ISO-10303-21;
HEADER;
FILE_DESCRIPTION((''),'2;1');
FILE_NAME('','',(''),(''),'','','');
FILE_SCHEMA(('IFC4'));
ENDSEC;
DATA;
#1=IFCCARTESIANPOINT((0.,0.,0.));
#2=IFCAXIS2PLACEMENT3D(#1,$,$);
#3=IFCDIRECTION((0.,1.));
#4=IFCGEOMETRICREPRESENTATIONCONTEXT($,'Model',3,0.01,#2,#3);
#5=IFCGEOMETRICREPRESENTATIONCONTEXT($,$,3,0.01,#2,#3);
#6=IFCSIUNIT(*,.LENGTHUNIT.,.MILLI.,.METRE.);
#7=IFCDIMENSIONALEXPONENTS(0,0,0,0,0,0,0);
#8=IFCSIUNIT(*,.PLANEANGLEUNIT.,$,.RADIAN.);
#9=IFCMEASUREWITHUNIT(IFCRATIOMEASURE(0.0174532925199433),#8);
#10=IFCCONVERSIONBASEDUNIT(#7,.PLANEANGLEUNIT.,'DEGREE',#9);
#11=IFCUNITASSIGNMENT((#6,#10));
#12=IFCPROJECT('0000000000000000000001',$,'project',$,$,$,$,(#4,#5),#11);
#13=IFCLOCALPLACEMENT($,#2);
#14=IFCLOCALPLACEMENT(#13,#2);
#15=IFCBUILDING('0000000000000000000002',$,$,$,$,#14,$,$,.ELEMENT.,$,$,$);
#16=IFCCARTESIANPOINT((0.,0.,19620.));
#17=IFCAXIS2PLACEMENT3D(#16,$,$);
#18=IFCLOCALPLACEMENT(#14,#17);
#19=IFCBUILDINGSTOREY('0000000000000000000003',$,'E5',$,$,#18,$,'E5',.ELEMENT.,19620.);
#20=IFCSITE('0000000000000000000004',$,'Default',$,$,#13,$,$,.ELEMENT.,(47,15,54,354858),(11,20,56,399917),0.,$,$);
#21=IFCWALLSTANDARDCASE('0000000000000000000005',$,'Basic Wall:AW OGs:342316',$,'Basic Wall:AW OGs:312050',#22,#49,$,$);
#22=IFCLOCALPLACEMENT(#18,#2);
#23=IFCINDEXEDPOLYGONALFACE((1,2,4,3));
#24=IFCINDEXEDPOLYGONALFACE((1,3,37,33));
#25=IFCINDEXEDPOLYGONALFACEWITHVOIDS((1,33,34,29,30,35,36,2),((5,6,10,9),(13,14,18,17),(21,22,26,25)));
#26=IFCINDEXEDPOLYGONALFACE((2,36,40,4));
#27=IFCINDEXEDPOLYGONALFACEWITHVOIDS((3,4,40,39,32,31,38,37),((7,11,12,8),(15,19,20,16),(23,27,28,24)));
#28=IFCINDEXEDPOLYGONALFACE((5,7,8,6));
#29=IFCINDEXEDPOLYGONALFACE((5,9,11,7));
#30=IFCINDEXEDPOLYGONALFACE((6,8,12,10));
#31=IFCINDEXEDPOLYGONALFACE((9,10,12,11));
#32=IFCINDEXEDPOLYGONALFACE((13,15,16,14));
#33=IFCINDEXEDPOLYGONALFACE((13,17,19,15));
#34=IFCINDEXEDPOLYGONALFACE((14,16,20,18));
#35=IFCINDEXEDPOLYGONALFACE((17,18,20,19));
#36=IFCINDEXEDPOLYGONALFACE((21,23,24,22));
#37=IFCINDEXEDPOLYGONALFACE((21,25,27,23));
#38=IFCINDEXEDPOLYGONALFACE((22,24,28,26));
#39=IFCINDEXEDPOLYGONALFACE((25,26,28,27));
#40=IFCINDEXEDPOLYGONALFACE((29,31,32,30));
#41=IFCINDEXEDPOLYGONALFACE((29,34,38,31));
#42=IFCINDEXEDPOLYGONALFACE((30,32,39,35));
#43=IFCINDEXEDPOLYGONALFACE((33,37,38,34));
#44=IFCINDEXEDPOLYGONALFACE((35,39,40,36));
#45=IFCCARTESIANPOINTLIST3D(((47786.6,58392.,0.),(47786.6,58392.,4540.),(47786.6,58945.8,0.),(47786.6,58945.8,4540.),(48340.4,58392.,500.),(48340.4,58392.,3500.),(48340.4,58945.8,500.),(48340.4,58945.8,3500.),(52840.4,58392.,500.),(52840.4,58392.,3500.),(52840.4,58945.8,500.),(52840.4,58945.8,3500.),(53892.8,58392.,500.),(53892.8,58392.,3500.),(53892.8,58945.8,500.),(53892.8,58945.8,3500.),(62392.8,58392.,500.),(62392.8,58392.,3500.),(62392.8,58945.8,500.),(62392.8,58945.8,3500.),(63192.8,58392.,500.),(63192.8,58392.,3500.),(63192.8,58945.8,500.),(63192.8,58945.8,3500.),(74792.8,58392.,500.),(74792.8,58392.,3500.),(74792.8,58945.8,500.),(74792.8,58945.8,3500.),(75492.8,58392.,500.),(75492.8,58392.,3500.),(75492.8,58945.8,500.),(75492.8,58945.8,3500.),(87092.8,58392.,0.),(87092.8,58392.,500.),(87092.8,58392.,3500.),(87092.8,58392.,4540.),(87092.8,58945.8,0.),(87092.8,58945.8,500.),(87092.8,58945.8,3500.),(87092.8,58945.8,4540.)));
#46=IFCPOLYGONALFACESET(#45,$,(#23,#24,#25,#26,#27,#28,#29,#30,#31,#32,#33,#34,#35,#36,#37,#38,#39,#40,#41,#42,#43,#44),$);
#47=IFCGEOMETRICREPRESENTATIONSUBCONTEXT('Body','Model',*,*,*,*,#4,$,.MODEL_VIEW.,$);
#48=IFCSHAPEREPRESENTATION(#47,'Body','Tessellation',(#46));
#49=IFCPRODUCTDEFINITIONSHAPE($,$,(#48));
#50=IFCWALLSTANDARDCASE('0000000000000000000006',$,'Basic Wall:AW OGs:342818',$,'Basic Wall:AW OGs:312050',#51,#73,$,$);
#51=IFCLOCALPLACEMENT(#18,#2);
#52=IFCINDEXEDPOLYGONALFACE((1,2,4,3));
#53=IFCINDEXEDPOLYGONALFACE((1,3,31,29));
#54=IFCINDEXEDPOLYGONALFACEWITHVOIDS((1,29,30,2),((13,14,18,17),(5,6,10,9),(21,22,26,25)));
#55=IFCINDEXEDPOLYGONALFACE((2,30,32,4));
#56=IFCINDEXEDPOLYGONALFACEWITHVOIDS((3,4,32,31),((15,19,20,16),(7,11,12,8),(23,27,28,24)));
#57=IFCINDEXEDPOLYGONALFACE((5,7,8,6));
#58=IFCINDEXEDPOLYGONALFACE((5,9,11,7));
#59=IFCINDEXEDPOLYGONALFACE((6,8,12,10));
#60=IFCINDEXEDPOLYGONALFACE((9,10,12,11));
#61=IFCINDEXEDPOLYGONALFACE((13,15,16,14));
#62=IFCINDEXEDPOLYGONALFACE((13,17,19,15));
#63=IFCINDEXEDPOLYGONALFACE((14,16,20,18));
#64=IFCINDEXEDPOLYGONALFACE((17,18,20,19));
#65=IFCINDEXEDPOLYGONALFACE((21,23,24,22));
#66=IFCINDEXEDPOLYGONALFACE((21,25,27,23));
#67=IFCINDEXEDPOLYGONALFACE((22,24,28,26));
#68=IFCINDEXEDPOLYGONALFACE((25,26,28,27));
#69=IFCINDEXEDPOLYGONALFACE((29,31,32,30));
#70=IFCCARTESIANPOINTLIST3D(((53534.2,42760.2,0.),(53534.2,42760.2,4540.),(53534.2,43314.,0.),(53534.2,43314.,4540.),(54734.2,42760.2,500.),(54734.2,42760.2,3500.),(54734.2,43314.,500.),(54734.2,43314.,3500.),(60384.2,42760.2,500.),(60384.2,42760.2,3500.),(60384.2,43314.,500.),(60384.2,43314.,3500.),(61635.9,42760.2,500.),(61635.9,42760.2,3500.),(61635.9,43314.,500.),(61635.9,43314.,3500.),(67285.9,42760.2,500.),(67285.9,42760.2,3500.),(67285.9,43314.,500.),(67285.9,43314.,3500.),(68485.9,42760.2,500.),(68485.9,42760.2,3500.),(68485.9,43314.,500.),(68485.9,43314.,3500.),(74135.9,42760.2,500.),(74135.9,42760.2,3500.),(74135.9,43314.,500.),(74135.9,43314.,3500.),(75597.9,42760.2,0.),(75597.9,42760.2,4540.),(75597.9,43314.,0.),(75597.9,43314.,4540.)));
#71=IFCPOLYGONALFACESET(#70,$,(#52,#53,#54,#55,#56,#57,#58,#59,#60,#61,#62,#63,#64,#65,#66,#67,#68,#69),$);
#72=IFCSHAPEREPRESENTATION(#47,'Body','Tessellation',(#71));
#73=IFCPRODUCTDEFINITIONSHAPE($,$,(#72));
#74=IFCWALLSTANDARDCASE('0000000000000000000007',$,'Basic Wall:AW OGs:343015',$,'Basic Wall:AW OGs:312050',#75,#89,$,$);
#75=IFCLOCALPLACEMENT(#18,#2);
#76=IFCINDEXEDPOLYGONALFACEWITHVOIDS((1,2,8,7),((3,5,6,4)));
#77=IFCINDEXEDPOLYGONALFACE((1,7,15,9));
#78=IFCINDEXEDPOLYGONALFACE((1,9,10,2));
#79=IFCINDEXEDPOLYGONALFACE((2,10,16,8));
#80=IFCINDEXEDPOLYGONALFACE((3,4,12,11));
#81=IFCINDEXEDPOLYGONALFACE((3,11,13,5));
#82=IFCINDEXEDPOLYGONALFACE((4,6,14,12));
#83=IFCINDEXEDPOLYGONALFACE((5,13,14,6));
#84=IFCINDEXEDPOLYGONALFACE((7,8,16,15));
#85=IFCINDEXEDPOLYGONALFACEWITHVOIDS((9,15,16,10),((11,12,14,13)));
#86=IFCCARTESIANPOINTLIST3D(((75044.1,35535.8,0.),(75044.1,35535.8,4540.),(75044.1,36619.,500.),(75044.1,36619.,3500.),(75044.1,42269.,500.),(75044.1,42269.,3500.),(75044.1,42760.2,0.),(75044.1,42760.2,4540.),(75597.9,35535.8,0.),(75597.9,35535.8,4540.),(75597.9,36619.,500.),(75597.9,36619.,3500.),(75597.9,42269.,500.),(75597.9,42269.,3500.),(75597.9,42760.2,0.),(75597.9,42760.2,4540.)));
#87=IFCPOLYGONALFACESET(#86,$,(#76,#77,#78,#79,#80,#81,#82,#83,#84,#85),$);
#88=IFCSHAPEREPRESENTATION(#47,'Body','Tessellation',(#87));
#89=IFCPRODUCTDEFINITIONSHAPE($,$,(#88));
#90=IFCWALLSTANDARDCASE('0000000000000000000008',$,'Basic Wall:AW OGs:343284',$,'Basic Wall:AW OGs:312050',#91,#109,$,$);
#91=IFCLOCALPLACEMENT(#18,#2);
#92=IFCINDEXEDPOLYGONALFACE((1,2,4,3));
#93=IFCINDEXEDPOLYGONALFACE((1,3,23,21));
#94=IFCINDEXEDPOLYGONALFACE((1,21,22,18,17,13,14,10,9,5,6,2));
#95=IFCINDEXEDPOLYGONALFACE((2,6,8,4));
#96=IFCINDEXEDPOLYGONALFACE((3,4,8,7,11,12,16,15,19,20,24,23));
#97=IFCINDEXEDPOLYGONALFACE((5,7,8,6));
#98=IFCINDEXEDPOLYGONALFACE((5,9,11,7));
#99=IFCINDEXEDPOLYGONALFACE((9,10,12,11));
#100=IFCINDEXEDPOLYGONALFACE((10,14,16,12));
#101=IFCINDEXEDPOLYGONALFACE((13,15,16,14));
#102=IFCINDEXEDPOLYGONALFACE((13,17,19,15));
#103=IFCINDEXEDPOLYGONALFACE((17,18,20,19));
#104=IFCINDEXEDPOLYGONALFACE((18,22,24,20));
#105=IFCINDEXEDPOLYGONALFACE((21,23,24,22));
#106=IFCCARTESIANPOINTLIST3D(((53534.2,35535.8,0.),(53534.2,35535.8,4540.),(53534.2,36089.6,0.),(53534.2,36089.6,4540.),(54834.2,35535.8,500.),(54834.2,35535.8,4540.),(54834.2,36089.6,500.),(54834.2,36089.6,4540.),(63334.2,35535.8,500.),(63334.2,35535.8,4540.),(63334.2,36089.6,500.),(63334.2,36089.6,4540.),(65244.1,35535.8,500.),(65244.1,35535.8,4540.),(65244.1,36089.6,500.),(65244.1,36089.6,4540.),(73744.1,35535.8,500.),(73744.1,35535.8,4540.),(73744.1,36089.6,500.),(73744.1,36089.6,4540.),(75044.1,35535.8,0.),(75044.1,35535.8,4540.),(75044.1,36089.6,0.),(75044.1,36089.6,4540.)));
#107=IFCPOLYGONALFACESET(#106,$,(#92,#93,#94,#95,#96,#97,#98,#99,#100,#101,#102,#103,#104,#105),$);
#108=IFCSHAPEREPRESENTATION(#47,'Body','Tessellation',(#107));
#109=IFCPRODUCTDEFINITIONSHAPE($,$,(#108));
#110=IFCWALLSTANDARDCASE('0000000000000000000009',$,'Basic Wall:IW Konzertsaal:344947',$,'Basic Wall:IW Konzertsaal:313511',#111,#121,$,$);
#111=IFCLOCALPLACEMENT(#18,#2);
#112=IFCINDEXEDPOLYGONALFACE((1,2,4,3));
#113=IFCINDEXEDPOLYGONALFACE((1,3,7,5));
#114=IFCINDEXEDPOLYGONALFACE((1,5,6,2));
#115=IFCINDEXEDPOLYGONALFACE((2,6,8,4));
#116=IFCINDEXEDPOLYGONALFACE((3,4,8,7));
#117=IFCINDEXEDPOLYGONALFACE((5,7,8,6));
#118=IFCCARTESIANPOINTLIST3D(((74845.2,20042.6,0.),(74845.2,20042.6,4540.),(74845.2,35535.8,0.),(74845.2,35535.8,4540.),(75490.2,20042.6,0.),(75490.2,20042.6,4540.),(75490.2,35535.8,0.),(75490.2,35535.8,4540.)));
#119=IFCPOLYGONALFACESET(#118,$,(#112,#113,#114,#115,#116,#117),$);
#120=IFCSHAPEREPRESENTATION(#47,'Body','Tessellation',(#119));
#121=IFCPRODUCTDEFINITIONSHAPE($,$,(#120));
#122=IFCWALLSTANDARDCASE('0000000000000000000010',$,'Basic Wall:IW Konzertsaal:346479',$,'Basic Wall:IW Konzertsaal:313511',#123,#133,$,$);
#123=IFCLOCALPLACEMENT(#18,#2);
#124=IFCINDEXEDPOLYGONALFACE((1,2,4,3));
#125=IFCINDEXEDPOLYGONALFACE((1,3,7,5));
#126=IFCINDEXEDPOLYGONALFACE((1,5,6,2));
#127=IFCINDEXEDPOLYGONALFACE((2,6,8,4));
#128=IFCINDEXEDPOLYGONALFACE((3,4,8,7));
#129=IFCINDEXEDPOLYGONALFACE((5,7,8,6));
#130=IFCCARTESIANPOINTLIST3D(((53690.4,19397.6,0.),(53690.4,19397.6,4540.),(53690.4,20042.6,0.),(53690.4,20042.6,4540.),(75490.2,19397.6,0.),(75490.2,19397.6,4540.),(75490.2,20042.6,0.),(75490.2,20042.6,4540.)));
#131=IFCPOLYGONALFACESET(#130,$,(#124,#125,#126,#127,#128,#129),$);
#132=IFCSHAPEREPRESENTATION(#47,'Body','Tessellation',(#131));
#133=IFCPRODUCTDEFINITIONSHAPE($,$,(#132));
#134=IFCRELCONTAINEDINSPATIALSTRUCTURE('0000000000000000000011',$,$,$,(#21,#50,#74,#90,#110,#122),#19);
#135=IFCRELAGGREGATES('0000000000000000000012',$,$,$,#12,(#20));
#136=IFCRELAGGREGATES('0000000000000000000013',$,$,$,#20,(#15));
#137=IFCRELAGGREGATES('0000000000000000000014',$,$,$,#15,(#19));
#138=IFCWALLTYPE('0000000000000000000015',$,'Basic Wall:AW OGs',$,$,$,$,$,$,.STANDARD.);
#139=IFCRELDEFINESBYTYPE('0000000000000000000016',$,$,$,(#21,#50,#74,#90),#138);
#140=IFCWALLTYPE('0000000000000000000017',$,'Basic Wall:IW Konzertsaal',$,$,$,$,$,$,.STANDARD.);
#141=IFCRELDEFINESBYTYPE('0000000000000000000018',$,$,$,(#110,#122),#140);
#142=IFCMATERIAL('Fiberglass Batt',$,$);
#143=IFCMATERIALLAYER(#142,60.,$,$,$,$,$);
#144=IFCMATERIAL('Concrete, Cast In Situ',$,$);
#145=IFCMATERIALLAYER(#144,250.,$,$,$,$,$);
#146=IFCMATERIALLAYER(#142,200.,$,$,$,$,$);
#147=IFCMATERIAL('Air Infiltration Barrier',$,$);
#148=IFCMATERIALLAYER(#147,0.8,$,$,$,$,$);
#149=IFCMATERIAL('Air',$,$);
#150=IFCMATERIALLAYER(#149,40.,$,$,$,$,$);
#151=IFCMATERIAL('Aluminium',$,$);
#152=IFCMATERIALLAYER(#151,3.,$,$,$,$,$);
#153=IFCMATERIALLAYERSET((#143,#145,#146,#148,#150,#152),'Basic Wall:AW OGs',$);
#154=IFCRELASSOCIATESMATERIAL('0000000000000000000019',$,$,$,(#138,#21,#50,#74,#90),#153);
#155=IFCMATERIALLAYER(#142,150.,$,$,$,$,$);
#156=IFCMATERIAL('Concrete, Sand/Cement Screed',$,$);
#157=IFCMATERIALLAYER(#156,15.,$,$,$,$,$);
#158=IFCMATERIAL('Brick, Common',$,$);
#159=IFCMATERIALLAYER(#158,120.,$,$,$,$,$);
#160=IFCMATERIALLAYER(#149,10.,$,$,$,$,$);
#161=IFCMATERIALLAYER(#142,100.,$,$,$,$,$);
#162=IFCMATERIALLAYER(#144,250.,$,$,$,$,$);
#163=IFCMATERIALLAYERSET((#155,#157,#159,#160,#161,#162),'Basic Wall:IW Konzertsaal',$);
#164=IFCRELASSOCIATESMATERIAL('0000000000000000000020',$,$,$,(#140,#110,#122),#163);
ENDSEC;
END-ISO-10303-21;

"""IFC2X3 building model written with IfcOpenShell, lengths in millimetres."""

from ifc_helpers import new_model, entity, si_unit, converted_unit, direction, frame, frame_2d, origin, place, context, subcontext, project, spatial, rectangle, extrude, material, layer, layer_set, layer_usage, type_object, element, save


model = new_model("IFC2X3")

# Units and contexts
model_context = context("Model", 3, precision=0.01, world=origin(), true_north=direction((0.0, 1.0)))
context_of_model = context(None, 3, precision=0.01, world=origin(), true_north=direction((0.0, 1.0)))
body_context = subcontext(model_context, "Body", "Model", "MODEL_VIEW")
ifc_project = project(units=[si_unit("LENGTHUNIT", "METRE", prefix="MILLI"), converted_unit("PLANEANGLEUNIT", "DEGREE", entity("IfcRatioMeasure", 0.0174532925199433), si_unit("PLANEANGLEUNIT", "RADIAN"), dimensions=[0, 0, 0, 0, 0, 0, 0])], contexts=[model_context, context_of_model])

# Site, building, storey
site_placement = place(None, origin())
site = spatial("IfcSite", under=ifc_project, at=site_placement, Name="Default", CompositionType="ELEMENT", RefLatitude=(47, 15, 54, 354858), RefLongitude=(11, 20, 56, 399917), RefElevation=0.0)
building_placement = place(site_placement, origin())
building = spatial("IfcBuilding", under=site, at=building_placement, CompositionType="ELEMENT")
storey_placement = place(building_placement, frame((0.0, 0.0, 19620.0)))
storey = spatial("IfcBuildingStorey", under=building, at=storey_placement, Name="E5", LongName="E5", CompositionType="ELEMENT", Elevation=19620.0)

# Shared definitions
ifc_material_1 = material(Name="Concrete, Cast In Situ")

# Walls, openings
ifc_material_2 = material(Name="Fiberglass Batt")
ifc_layer_1 = layer(ifc_material_2, 60.0)
ifc_layer_2 = layer(ifc_material_1, 250.0)
ifc_layer_3 = layer(ifc_material_2, 200.0)
ifc_material_3 = material(Name="Air Infiltration Barrier")
ifc_layer_4 = layer(ifc_material_3, 0.8)
ifc_material_4 = material(Name="Air")
ifc_layer_5 = layer(ifc_material_4, 40.0)
ifc_material_5 = material(Name="Aluminium")
ifc_layer_6 = layer(ifc_material_5, 3.0)
ifc_layer_set_1 = layer_set([ifc_layer_1, ifc_layer_2, ifc_layer_3, ifc_layer_4, ifc_layer_5, ifc_layer_6], Name="Basic Wall:AW OGs")
wall_type_1 = type_object("IfcWallType", Name="Basic Wall:AW OGs", PredefinedType="STANDARD", material=ifc_layer_set_1)
ifc_layer_usage_1 = layer_usage(ifc_layer_set_1, "AXIS2", "NEGATIVE", 276.9)
wall_1_placement = place(storey_placement, frame((87092.8, 58668.9, 0.0), z_axis=(0.0, 0.0, 1.0), x_axis=(-1.0, 0.0, 0.0)))
wall_1 = element("IfcWallStandardCase", 1, at=wall_1_placement, inside=storey, type_object=wall_type_1, material=ifc_layer_usage_1, Name="Basic Wall:AW OGs:342316", ObjectType="Basic Wall:AW OGs:312050", context=body_context, shape_type="SweptSolid", body=[
    extrude(rectangle(XDim=39306.2, YDim=553.8, at=frame_2d((19653.1, 0.0), x_axis=(-1.0, 0.0))), origin(), (0.0, 0.0, 1.0), 4540.0),
])
opening_1_placement = place(wall_1_placement, frame((11600.0, 276.9, 500.0)))
element("IfcOpeningElement", 2, at=opening_1_placement, cuts=wall_1, ObjectType="Opening", context=body_context, shape_type="SweptSolid", body=[
    extrude(rectangle(XDim=3000.0, YDim=11600.0, at=frame_2d((1500.0, 5800.0), x_axis=(-1.0, 0.0))), frame((0.0, 0.0, 0.0), z_axis=(0.0, -1.0, 0.0), x_axis=(0.0, 0.0, 1.0)), (0.0, 0.0, 1.0), 553.8),
])
opening_2_placement = place(wall_1_placement, frame((38752.4, 276.9, 500.0)))
element("IfcOpeningElement", 3, at=opening_2_placement, cuts=wall_1, ObjectType="Opening", context=body_context, shape_type="SweptSolid", body=[
    extrude(rectangle(XDim=3000.0, YDim=4500.0, at=frame_2d((1500.0, 2250.0), x_axis=(-1.0, 0.0))), frame((0.0, 0.0, 0.0), z_axis=(0.0, -1.0, 0.0), x_axis=(0.0, 0.0, 1.0)), (0.0, 0.0, 1.0), 553.8),
])
opening_3_placement = place(wall_1_placement, frame((23900.0, 276.9, 500.0)))
element("IfcOpeningElement", 4, at=opening_3_placement, cuts=wall_1, ObjectType="Opening", context=body_context, shape_type="SweptSolid", body=[
    extrude(rectangle(XDim=3000.0, YDim=11600.0, at=frame_2d((1500.0, 5800.0), x_axis=(-1.0, 0.0))), frame((0.0, 0.0, 0.0), z_axis=(0.0, -1.0, 0.0), x_axis=(0.0, 0.0, 1.0)), (0.0, 0.0, 1.0), 553.8),
])
opening_4_placement = place(wall_1_placement, frame((33200.0, 276.9, 500.0)))
element("IfcOpeningElement", 5, at=opening_4_placement, cuts=wall_1, ObjectType="Opening", context=body_context, shape_type="SweptSolid", body=[
    extrude(rectangle(XDim=3000.0, YDim=8500.0, at=frame_2d((1500.0, 4250.0), x_axis=(-1.0, 0.0))), frame((0.0, 0.0, 0.0), z_axis=(0.0, -1.0, 0.0), x_axis=(0.0, 0.0, 1.0)), (0.0, 0.0, 1.0), 553.8),
])
ifc_layer_usage_2 = layer_usage(ifc_layer_set_1, "AXIS2", "NEGATIVE", 276.9)
wall_2_placement = place(storey_placement, frame((53534.2, 43037.1, 0.0)))
wall_2 = element("IfcWallStandardCase", 6, at=wall_2_placement, inside=storey, type_object=wall_type_1, material=ifc_layer_usage_2, Name="Basic Wall:AW OGs:342818", ObjectType="Basic Wall:AW OGs:312050", context=body_context, shape_type="SweptSolid", body=[
    extrude(rectangle(XDim=22063.7, YDim=553.8, at=frame_2d((11031.8, 0.0), x_axis=(-1.0, 0.0))), origin(), (0.0, 0.0, 1.0), 4540.0),
])
opening_5_placement = place(wall_2_placement, frame((6850.0, 276.9, 500.0)))
element("IfcOpeningElement", 7, at=opening_5_placement, cuts=wall_2, ObjectType="Opening", context=body_context, shape_type="SweptSolid", body=[
    extrude(rectangle(XDim=3000.0, YDim=5650.0, at=frame_2d((1500.0, 2825.0), x_axis=(-1.0, 0.0))), frame((0.0, 0.0, 0.0), z_axis=(0.0, -1.0, 0.0), x_axis=(0.0, 0.0, 1.0)), (0.0, 0.0, 1.0), 553.8),
])
opening_6_placement = place(wall_2_placement, frame((13751.8, 276.9, 500.0)))
element("IfcOpeningElement", 8, at=opening_6_placement, cuts=wall_2, ObjectType="Opening", context=body_context, shape_type="SweptSolid", body=[
    extrude(rectangle(XDim=3000.0, YDim=5650.0, at=frame_2d((1500.0, 2825.0), x_axis=(-1.0, 0.0))), frame((0.0, 0.0, 0.0), z_axis=(0.0, -1.0, 0.0), x_axis=(0.0, 0.0, 1.0)), (0.0, 0.0, 1.0), 553.8),
])
opening_7_placement = place(wall_2_placement, frame((20601.8, 276.9, 500.0)))
element("IfcOpeningElement", 9, at=opening_7_placement, cuts=wall_2, ObjectType="Opening", context=body_context, shape_type="SweptSolid", body=[
    extrude(rectangle(XDim=3000.0, YDim=5650.0, at=frame_2d((1500.0, 2825.0), x_axis=(-1.0, 0.0))), frame((0.0, 0.0, 0.0), z_axis=(0.0, -1.0, 0.0), x_axis=(0.0, 0.0, 1.0)), (0.0, 0.0, 1.0), 553.8),
])

# Wall, opening
ifc_layer_usage_3 = layer_usage(ifc_layer_set_1, "AXIS2", "NEGATIVE", 276.9)
wall_3_placement = place(storey_placement, frame((75321.0, 42760.2, 0.0), z_axis=(0.0, 0.0, 1.0), x_axis=(0.0, -1.0, 0.0)))
wall_3 = element("IfcWallStandardCase", 10, at=wall_3_placement, inside=storey, type_object=wall_type_1, material=ifc_layer_usage_3, Name="Basic Wall:AW OGs:343015", ObjectType="Basic Wall:AW OGs:312050", context=body_context, shape_type="SweptSolid", body=[
    extrude(rectangle(XDim=7224.4, YDim=553.8, at=frame_2d((3612.2, 0.0), x_axis=(-1.0, 0.0))), origin(), (0.0, 0.0, 1.0), 4540.0),
])
opening_8_placement = place(wall_3_placement, frame((6141.2, 276.9, 500.0)))
element("IfcOpeningElement", 11, at=opening_8_placement, cuts=wall_3, ObjectType="Opening", context=body_context, shape_type="SweptSolid", body=[
    extrude(rectangle(XDim=3000.0, YDim=5650.0, at=frame_2d((1500.0, 2825.0), x_axis=(-1.0, 0.0))), frame((0.0, 0.0, 0.0), z_axis=(0.0, -1.0, 0.0), x_axis=(0.0, 0.0, 1.0)), (0.0, 0.0, 1.0), 553.8),
])

# Wall, openings
ifc_layer_usage_4 = layer_usage(ifc_layer_set_1, "AXIS2", "NEGATIVE", 276.9)
wall_4_placement = place(storey_placement, frame((75044.1, 35812.7, 0.0), z_axis=(0.0, 0.0, 1.0), x_axis=(-1.0, 0.0, 0.0)))
wall_4 = element("IfcWallStandardCase", 12, at=wall_4_placement, inside=storey, type_object=wall_type_1, material=ifc_layer_usage_4, Name="Basic Wall:AW OGs:343284", ObjectType="Basic Wall:AW OGs:312050", context=body_context, shape_type="SweptSolid", body=[
    extrude(rectangle(XDim=21509.9, YDim=553.8, at=frame_2d((10754.9, 0.0), x_axis=(-1.0, 0.0))), origin(), (0.0, 0.0, 1.0), 4540.0),
])
opening_9_placement = place(wall_4_placement, frame((9800.0, 276.9, 500.0)))
element("IfcOpeningElement", 13, at=opening_9_placement, cuts=wall_4, ObjectType="Opening", context=body_context, shape_type="SweptSolid", body=[
    extrude(rectangle(XDim=6000.0, YDim=8500.0, at=frame_2d((3000.0, 4250.0), x_axis=(-1.0, 0.0))), frame((0.0, 0.0, 0.0), z_axis=(0.0, -1.0, 0.0), x_axis=(0.0, 0.0, 1.0)), (0.0, 0.0, 1.0), 553.8),
])
opening_10_placement = place(wall_4_placement, frame((20209.9, 276.9, 500.0)))
element("IfcOpeningElement", 14, at=opening_10_placement, cuts=wall_4, ObjectType="Opening", context=body_context, shape_type="SweptSolid", body=[
    extrude(rectangle(XDim=6000.0, YDim=8500.0, at=frame_2d((3000.0, 4250.0), x_axis=(-1.0, 0.0))), frame((0.0, 0.0, 0.0), z_axis=(0.0, -1.0, 0.0), x_axis=(0.0, 0.0, 1.0)), (0.0, 0.0, 1.0), 553.8),
])

# Walls
ifc_layer_7 = layer(ifc_material_2, 150.0)
ifc_material_6 = material(Name="Concrete, Sand/Cement Screed")
ifc_layer_8 = layer(ifc_material_6, 15.0)
ifc_material_7 = material(Name="Brick, Common")
ifc_layer_9 = layer(ifc_material_7, 120.0)
ifc_layer_10 = layer(ifc_material_4, 10.0)
ifc_layer_11 = layer(ifc_material_2, 100.0)
ifc_layer_12 = layer(ifc_material_1, 250.0)
ifc_layer_set_2 = layer_set([ifc_layer_7, ifc_layer_8, ifc_layer_9, ifc_layer_10, ifc_layer_11, ifc_layer_12], Name="Basic Wall:IW Konzertsaal")
ifc_layer_usage_5 = layer_usage(ifc_layer_set_2, "AXIS2", "POSITIVE", -322.5)
wall_type_2 = type_object("IfcWallType", Name="Basic Wall:IW Konzertsaal", PredefinedType="STANDARD", material=ifc_layer_set_2)
wall_5_placement = place(storey_placement, frame((75167.7, 35535.8, 0.0), z_axis=(0.0, 0.0, 1.0), x_axis=(0.0, -1.0, 0.0)))
element("IfcWallStandardCase", 15, at=wall_5_placement, inside=storey, type_object=wall_type_2, material=ifc_layer_usage_5, Name="Basic Wall:IW Konzertsaal:344947", ObjectType="Basic Wall:IW Konzertsaal:313511", context=body_context, shape_type="SweptSolid", body=[
    extrude(rectangle(XDim=15493.2, YDim=645.0, at=frame_2d((7746.6, 0.0), x_axis=(-1.0, 0.0))), origin(), (0.0, 0.0, 1.0), 4540.0),
])
ifc_layer_usage_6 = layer_usage(ifc_layer_set_2, "AXIS2", "NEGATIVE", 322.5)
wall_6_placement = place(storey_placement, frame((53690.4, 19720.1, 0.0)))
element("IfcWallStandardCase", 16, at=wall_6_placement, inside=storey, type_object=wall_type_2, material=ifc_layer_usage_6, Name="Basic Wall:IW Konzertsaal:346479", ObjectType="Basic Wall:IW Konzertsaal:313511", context=body_context, shape_type="SweptSolid", body=[
    extrude(rectangle(XDim=21799.8, YDim=645.0, at=frame_2d((10899.9, 0.0), x_axis=(-1.0, 0.0))), origin(), (0.0, 0.0, 1.0), 4540.0),
])

save(model, "model.ifc")
